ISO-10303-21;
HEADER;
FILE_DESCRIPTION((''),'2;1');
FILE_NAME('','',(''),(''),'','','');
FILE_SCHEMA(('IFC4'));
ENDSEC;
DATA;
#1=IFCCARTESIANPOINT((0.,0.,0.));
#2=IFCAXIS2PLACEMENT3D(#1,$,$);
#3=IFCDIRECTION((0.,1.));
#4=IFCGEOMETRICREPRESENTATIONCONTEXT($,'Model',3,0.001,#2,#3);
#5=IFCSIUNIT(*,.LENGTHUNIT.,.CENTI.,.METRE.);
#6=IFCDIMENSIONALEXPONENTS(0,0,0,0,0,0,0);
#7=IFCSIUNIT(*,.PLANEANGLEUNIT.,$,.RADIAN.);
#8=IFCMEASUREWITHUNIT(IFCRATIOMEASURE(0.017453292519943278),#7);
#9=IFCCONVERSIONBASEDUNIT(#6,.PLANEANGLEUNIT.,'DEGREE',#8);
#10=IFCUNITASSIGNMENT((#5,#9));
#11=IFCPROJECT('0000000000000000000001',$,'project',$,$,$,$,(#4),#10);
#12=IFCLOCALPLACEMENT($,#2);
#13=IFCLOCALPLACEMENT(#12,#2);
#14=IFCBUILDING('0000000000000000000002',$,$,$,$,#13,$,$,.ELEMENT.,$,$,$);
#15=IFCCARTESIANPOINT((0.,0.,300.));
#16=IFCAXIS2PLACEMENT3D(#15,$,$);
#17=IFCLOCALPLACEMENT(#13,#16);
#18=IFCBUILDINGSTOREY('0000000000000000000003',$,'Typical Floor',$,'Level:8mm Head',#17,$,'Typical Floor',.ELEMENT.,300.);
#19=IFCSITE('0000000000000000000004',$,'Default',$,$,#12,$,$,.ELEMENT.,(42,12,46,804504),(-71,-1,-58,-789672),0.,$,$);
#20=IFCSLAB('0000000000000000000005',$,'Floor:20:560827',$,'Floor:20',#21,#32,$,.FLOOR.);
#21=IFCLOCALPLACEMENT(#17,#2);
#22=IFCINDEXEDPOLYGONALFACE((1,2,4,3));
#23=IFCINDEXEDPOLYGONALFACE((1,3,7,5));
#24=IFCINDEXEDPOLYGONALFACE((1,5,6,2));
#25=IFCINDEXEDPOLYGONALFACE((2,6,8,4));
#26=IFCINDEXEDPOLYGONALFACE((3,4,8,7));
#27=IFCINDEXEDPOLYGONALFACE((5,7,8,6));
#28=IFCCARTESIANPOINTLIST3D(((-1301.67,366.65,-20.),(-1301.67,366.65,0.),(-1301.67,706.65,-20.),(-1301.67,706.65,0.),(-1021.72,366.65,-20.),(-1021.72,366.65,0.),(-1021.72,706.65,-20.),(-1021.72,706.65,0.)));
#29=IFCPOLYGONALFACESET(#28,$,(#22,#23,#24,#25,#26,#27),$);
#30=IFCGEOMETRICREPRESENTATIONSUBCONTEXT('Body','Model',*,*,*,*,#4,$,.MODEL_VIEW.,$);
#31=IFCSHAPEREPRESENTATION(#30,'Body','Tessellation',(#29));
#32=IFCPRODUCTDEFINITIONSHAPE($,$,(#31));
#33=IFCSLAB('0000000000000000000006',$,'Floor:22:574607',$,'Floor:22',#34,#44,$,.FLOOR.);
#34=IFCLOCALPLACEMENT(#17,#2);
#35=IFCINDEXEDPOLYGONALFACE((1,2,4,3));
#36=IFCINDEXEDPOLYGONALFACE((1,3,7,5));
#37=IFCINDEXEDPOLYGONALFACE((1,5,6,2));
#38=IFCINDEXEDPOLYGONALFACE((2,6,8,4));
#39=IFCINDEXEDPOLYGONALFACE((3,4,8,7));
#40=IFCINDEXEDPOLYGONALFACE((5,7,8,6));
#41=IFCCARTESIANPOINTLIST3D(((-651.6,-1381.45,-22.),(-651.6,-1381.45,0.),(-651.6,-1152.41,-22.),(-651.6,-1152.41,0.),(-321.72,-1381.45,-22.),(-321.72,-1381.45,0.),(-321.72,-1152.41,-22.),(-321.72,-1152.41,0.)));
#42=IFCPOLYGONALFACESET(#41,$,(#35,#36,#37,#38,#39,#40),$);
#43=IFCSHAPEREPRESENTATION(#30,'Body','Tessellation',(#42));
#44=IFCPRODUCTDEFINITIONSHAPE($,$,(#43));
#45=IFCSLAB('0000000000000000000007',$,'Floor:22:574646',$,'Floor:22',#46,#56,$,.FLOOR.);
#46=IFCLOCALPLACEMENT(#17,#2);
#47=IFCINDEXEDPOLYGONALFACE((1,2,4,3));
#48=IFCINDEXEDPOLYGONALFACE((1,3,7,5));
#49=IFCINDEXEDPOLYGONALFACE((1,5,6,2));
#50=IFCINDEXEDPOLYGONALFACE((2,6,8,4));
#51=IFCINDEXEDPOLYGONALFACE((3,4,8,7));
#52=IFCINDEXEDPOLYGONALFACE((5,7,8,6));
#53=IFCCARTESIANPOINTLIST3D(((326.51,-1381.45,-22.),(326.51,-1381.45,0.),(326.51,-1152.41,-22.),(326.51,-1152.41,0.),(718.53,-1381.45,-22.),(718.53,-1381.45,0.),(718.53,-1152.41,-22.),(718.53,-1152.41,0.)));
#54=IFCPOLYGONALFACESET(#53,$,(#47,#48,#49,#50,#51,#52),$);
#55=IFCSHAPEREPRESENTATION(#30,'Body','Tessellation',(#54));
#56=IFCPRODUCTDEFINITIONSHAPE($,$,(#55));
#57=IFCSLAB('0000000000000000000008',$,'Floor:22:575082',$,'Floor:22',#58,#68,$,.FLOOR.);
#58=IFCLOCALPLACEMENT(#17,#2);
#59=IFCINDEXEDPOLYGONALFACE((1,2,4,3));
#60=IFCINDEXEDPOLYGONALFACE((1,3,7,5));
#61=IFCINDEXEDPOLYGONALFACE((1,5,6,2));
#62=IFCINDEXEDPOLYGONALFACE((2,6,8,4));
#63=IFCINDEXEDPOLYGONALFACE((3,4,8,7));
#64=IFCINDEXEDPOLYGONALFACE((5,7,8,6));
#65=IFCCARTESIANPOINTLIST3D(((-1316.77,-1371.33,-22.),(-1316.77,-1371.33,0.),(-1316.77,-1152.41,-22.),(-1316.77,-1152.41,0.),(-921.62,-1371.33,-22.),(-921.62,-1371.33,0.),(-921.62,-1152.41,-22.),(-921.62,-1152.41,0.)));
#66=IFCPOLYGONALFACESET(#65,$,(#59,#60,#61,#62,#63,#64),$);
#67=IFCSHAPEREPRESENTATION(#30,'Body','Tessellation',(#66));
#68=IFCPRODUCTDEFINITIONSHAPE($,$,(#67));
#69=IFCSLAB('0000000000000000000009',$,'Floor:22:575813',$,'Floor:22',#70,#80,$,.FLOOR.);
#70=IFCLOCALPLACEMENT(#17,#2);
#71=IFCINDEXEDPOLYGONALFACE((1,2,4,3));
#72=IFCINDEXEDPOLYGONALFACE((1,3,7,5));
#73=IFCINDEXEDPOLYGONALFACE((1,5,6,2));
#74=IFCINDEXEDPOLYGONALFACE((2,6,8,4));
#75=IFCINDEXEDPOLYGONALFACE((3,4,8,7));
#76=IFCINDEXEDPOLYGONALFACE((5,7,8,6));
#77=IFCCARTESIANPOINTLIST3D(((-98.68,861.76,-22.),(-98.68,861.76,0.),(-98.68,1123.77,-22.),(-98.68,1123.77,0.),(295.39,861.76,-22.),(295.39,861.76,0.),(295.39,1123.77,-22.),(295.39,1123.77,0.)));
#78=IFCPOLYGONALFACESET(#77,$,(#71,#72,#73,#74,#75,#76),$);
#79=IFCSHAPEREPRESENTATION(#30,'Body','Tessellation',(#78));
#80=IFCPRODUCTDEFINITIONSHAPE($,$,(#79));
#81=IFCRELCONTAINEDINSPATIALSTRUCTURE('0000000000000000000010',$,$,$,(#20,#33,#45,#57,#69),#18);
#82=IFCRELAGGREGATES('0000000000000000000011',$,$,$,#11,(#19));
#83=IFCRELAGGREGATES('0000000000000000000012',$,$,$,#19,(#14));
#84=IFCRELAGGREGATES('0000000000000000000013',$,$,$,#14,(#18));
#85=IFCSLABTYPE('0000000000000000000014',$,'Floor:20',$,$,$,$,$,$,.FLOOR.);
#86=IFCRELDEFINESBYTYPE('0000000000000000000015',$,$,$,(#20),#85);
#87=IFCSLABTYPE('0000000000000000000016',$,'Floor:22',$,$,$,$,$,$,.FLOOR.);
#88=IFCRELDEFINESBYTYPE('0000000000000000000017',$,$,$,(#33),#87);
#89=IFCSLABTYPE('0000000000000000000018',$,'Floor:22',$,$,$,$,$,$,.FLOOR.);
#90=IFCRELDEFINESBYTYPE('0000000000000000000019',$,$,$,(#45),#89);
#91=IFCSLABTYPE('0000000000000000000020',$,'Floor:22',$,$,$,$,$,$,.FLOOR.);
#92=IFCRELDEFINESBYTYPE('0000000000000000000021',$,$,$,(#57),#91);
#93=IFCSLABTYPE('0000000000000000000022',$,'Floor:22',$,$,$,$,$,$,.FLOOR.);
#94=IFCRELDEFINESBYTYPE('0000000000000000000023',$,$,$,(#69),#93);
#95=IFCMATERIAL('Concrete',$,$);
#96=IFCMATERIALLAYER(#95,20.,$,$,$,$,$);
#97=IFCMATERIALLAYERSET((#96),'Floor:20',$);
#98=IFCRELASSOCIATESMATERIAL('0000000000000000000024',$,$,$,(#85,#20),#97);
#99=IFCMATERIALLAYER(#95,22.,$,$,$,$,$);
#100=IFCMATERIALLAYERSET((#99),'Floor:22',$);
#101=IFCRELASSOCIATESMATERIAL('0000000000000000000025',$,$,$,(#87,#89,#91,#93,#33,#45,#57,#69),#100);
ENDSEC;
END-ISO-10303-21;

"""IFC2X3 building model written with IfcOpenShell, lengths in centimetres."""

from ifc_helpers import new_model, entity, si_unit, converted_unit, direction, frame, frame_2d, origin, place, context, subcontext, project, spatial, rectangle, extrude, material, layer, layer_set, layer_usage, type_object, element, save


model = new_model("IFC2X3")

# Units and contexts
model_context = context("Model", 3, precision=0.001, world=origin(), true_north=direction((0.0, 1.0)))
body_context = subcontext(model_context, "Body", "Model", "MODEL_VIEW")
ifc_project = project(units=[si_unit("LENGTHUNIT", "METRE", prefix="CENTI"), converted_unit("PLANEANGLEUNIT", "DEGREE", entity("IfcRatioMeasure", 0.017453292519943278), si_unit("PLANEANGLEUNIT", "RADIAN"), dimensions=[0, 0, 0, 0, 0, 0, 0])], contexts=[model_context])

# Site, building, storey
site_placement = place(None, origin())
site = spatial("IfcSite", under=ifc_project, at=site_placement, Name="Default", CompositionType="ELEMENT", RefLatitude=(42, 12, 46, 804504), RefLongitude=(-71, -1, -58, -789672), RefElevation=0.0)
building_placement = place(site_placement, origin())
building = spatial("IfcBuilding", under=site, at=building_placement, CompositionType="ELEMENT")
storey_placement = place(building_placement, frame((0.0, 0.0, 300.0)))
storey = spatial("IfcBuildingStorey", under=building, at=storey_placement, Name="Typical Floor", ObjectType="Level:8mm Head", LongName="Typical Floor", CompositionType="ELEMENT", Elevation=300.0)

# Shared definitions
ifc_material = material(Name="Concrete")

# Slabs
ifc_layer_1 = layer(ifc_material, 22.0)
ifc_layer_set_1 = layer_set([ifc_layer_1], Name="Floor:22")
ifc_layer_2 = layer(ifc_material, 20.0)
ifc_layer_set_2 = layer_set([ifc_layer_2], Name="Floor:20")
ifc_layer_usage_1 = layer_usage(ifc_layer_set_2, "AXIS3", "POSITIVE", 0.0)
slab_type_1 = type_object("IfcSlabType", Name="Floor:20", PredefinedType="FLOOR", material=ifc_layer_set_2)
slab_1_placement = place(storey_placement, origin())
element("IfcSlab", 1, at=slab_1_placement, inside=storey, type_object=slab_type_1, material=ifc_layer_usage_1, Name="Floor:20:560827", ObjectType="Floor:20", PredefinedType="FLOOR", context=body_context, shape_type="SweptSolid", body=[
    extrude(rectangle(XDim=340.0, YDim=279.95, at=frame_2d((0.0, 0.0), x_axis=(1.0, 0.0))), frame((-1161.7, 536.65, 0.0), z_axis=(0.0, 0.0, -1.0), x_axis=(0.0, 1.0, 0.0)), (0.0, 0.0, 1.0), 20.0),
])
ifc_layer_usage_2 = layer_usage(ifc_layer_set_1, "AXIS3", "POSITIVE", 0.0)
slab_type_2 = type_object("IfcSlabType", Name="Floor:22", PredefinedType="FLOOR", material=ifc_layer_set_1)
slab_2_placement = place(storey_placement, origin())
element("IfcSlab", 2, at=slab_2_placement, inside=storey, type_object=slab_type_2, material=ifc_layer_usage_2, Name="Floor:22:574607", ObjectType="Floor:22", PredefinedType="FLOOR", context=body_context, shape_type="SweptSolid", body=[
    extrude(rectangle(XDim=229.04, YDim=329.88, at=frame_2d((0.0, 0.0), x_axis=(1.0, 0.0))), frame((-486.66, -1266.93, 0.0), z_axis=(0.0, 0.0, -1.0), x_axis=(0.0, 1.0, 0.0)), (0.0, 0.0, 1.0), 22.0),
])
ifc_layer_usage_3 = layer_usage(ifc_layer_set_1, "AXIS3", "POSITIVE", 0.0)
slab_type_3 = type_object("IfcSlabType", Name="Floor:22", PredefinedType="FLOOR", material=ifc_layer_set_1)
slab_3_placement = place(storey_placement, origin())
element("IfcSlab", 3, at=slab_3_placement, inside=storey, type_object=slab_type_3, material=ifc_layer_usage_3, Name="Floor:22:574646", ObjectType="Floor:22", PredefinedType="FLOOR", context=body_context, shape_type="SweptSolid", body=[
    extrude(rectangle(XDim=229.04, YDim=392.03, at=frame_2d((0.0, 0.0), x_axis=(1.0, 0.0))), frame((522.52, -1266.93, 0.0), z_axis=(0.0, 0.0, -1.0), x_axis=(0.0, 1.0, 0.0)), (0.0, 0.0, 1.0), 22.0),
])
ifc_layer_usage_4 = layer_usage(ifc_layer_set_1, "AXIS3", "POSITIVE", 0.0)
slab_type_4 = type_object("IfcSlabType", Name="Floor:22", PredefinedType="FLOOR", material=ifc_layer_set_1)
slab_4_placement = place(storey_placement, origin())
element("IfcSlab", 4, at=slab_4_placement, inside=storey, type_object=slab_type_4, material=ifc_layer_usage_4, Name="Floor:22:575082", ObjectType="Floor:22", PredefinedType="FLOOR", context=body_context, shape_type="SweptSolid", body=[
    extrude(rectangle(XDim=218.93, YDim=395.15, at=frame_2d((0.0, 0.0), x_axis=(1.0, 0.0))), frame((-1119.19, -1261.87, 0.0), z_axis=(0.0, 0.0, -1.0), x_axis=(0.0, 1.0, 0.0)), (0.0, 0.0, 1.0), 22.0),
])
ifc_layer_usage_5 = layer_usage(ifc_layer_set_1, "AXIS3", "POSITIVE", 0.0)
slab_type_5 = type_object("IfcSlabType", Name="Floor:22", PredefinedType="FLOOR", material=ifc_layer_set_1)
slab_5_placement = place(storey_placement, origin())
element("IfcSlab", 5, at=slab_5_placement, inside=storey, type_object=slab_type_5, material=ifc_layer_usage_5, Name="Floor:22:575813", ObjectType="Floor:22", PredefinedType="FLOOR", context=body_context, shape_type="SweptSolid", body=[
    extrude(rectangle(XDim=262.01, YDim=394.07, at=frame_2d((0.0, 0.0), x_axis=(1.0, 0.0))), frame((98.35, 992.77, 0.0), z_axis=(0.0, 0.0, -1.0), x_axis=(0.0, 1.0, 0.0)), (0.0, 0.0, 1.0), 22.0),
])

save(model, "model.ifc")
